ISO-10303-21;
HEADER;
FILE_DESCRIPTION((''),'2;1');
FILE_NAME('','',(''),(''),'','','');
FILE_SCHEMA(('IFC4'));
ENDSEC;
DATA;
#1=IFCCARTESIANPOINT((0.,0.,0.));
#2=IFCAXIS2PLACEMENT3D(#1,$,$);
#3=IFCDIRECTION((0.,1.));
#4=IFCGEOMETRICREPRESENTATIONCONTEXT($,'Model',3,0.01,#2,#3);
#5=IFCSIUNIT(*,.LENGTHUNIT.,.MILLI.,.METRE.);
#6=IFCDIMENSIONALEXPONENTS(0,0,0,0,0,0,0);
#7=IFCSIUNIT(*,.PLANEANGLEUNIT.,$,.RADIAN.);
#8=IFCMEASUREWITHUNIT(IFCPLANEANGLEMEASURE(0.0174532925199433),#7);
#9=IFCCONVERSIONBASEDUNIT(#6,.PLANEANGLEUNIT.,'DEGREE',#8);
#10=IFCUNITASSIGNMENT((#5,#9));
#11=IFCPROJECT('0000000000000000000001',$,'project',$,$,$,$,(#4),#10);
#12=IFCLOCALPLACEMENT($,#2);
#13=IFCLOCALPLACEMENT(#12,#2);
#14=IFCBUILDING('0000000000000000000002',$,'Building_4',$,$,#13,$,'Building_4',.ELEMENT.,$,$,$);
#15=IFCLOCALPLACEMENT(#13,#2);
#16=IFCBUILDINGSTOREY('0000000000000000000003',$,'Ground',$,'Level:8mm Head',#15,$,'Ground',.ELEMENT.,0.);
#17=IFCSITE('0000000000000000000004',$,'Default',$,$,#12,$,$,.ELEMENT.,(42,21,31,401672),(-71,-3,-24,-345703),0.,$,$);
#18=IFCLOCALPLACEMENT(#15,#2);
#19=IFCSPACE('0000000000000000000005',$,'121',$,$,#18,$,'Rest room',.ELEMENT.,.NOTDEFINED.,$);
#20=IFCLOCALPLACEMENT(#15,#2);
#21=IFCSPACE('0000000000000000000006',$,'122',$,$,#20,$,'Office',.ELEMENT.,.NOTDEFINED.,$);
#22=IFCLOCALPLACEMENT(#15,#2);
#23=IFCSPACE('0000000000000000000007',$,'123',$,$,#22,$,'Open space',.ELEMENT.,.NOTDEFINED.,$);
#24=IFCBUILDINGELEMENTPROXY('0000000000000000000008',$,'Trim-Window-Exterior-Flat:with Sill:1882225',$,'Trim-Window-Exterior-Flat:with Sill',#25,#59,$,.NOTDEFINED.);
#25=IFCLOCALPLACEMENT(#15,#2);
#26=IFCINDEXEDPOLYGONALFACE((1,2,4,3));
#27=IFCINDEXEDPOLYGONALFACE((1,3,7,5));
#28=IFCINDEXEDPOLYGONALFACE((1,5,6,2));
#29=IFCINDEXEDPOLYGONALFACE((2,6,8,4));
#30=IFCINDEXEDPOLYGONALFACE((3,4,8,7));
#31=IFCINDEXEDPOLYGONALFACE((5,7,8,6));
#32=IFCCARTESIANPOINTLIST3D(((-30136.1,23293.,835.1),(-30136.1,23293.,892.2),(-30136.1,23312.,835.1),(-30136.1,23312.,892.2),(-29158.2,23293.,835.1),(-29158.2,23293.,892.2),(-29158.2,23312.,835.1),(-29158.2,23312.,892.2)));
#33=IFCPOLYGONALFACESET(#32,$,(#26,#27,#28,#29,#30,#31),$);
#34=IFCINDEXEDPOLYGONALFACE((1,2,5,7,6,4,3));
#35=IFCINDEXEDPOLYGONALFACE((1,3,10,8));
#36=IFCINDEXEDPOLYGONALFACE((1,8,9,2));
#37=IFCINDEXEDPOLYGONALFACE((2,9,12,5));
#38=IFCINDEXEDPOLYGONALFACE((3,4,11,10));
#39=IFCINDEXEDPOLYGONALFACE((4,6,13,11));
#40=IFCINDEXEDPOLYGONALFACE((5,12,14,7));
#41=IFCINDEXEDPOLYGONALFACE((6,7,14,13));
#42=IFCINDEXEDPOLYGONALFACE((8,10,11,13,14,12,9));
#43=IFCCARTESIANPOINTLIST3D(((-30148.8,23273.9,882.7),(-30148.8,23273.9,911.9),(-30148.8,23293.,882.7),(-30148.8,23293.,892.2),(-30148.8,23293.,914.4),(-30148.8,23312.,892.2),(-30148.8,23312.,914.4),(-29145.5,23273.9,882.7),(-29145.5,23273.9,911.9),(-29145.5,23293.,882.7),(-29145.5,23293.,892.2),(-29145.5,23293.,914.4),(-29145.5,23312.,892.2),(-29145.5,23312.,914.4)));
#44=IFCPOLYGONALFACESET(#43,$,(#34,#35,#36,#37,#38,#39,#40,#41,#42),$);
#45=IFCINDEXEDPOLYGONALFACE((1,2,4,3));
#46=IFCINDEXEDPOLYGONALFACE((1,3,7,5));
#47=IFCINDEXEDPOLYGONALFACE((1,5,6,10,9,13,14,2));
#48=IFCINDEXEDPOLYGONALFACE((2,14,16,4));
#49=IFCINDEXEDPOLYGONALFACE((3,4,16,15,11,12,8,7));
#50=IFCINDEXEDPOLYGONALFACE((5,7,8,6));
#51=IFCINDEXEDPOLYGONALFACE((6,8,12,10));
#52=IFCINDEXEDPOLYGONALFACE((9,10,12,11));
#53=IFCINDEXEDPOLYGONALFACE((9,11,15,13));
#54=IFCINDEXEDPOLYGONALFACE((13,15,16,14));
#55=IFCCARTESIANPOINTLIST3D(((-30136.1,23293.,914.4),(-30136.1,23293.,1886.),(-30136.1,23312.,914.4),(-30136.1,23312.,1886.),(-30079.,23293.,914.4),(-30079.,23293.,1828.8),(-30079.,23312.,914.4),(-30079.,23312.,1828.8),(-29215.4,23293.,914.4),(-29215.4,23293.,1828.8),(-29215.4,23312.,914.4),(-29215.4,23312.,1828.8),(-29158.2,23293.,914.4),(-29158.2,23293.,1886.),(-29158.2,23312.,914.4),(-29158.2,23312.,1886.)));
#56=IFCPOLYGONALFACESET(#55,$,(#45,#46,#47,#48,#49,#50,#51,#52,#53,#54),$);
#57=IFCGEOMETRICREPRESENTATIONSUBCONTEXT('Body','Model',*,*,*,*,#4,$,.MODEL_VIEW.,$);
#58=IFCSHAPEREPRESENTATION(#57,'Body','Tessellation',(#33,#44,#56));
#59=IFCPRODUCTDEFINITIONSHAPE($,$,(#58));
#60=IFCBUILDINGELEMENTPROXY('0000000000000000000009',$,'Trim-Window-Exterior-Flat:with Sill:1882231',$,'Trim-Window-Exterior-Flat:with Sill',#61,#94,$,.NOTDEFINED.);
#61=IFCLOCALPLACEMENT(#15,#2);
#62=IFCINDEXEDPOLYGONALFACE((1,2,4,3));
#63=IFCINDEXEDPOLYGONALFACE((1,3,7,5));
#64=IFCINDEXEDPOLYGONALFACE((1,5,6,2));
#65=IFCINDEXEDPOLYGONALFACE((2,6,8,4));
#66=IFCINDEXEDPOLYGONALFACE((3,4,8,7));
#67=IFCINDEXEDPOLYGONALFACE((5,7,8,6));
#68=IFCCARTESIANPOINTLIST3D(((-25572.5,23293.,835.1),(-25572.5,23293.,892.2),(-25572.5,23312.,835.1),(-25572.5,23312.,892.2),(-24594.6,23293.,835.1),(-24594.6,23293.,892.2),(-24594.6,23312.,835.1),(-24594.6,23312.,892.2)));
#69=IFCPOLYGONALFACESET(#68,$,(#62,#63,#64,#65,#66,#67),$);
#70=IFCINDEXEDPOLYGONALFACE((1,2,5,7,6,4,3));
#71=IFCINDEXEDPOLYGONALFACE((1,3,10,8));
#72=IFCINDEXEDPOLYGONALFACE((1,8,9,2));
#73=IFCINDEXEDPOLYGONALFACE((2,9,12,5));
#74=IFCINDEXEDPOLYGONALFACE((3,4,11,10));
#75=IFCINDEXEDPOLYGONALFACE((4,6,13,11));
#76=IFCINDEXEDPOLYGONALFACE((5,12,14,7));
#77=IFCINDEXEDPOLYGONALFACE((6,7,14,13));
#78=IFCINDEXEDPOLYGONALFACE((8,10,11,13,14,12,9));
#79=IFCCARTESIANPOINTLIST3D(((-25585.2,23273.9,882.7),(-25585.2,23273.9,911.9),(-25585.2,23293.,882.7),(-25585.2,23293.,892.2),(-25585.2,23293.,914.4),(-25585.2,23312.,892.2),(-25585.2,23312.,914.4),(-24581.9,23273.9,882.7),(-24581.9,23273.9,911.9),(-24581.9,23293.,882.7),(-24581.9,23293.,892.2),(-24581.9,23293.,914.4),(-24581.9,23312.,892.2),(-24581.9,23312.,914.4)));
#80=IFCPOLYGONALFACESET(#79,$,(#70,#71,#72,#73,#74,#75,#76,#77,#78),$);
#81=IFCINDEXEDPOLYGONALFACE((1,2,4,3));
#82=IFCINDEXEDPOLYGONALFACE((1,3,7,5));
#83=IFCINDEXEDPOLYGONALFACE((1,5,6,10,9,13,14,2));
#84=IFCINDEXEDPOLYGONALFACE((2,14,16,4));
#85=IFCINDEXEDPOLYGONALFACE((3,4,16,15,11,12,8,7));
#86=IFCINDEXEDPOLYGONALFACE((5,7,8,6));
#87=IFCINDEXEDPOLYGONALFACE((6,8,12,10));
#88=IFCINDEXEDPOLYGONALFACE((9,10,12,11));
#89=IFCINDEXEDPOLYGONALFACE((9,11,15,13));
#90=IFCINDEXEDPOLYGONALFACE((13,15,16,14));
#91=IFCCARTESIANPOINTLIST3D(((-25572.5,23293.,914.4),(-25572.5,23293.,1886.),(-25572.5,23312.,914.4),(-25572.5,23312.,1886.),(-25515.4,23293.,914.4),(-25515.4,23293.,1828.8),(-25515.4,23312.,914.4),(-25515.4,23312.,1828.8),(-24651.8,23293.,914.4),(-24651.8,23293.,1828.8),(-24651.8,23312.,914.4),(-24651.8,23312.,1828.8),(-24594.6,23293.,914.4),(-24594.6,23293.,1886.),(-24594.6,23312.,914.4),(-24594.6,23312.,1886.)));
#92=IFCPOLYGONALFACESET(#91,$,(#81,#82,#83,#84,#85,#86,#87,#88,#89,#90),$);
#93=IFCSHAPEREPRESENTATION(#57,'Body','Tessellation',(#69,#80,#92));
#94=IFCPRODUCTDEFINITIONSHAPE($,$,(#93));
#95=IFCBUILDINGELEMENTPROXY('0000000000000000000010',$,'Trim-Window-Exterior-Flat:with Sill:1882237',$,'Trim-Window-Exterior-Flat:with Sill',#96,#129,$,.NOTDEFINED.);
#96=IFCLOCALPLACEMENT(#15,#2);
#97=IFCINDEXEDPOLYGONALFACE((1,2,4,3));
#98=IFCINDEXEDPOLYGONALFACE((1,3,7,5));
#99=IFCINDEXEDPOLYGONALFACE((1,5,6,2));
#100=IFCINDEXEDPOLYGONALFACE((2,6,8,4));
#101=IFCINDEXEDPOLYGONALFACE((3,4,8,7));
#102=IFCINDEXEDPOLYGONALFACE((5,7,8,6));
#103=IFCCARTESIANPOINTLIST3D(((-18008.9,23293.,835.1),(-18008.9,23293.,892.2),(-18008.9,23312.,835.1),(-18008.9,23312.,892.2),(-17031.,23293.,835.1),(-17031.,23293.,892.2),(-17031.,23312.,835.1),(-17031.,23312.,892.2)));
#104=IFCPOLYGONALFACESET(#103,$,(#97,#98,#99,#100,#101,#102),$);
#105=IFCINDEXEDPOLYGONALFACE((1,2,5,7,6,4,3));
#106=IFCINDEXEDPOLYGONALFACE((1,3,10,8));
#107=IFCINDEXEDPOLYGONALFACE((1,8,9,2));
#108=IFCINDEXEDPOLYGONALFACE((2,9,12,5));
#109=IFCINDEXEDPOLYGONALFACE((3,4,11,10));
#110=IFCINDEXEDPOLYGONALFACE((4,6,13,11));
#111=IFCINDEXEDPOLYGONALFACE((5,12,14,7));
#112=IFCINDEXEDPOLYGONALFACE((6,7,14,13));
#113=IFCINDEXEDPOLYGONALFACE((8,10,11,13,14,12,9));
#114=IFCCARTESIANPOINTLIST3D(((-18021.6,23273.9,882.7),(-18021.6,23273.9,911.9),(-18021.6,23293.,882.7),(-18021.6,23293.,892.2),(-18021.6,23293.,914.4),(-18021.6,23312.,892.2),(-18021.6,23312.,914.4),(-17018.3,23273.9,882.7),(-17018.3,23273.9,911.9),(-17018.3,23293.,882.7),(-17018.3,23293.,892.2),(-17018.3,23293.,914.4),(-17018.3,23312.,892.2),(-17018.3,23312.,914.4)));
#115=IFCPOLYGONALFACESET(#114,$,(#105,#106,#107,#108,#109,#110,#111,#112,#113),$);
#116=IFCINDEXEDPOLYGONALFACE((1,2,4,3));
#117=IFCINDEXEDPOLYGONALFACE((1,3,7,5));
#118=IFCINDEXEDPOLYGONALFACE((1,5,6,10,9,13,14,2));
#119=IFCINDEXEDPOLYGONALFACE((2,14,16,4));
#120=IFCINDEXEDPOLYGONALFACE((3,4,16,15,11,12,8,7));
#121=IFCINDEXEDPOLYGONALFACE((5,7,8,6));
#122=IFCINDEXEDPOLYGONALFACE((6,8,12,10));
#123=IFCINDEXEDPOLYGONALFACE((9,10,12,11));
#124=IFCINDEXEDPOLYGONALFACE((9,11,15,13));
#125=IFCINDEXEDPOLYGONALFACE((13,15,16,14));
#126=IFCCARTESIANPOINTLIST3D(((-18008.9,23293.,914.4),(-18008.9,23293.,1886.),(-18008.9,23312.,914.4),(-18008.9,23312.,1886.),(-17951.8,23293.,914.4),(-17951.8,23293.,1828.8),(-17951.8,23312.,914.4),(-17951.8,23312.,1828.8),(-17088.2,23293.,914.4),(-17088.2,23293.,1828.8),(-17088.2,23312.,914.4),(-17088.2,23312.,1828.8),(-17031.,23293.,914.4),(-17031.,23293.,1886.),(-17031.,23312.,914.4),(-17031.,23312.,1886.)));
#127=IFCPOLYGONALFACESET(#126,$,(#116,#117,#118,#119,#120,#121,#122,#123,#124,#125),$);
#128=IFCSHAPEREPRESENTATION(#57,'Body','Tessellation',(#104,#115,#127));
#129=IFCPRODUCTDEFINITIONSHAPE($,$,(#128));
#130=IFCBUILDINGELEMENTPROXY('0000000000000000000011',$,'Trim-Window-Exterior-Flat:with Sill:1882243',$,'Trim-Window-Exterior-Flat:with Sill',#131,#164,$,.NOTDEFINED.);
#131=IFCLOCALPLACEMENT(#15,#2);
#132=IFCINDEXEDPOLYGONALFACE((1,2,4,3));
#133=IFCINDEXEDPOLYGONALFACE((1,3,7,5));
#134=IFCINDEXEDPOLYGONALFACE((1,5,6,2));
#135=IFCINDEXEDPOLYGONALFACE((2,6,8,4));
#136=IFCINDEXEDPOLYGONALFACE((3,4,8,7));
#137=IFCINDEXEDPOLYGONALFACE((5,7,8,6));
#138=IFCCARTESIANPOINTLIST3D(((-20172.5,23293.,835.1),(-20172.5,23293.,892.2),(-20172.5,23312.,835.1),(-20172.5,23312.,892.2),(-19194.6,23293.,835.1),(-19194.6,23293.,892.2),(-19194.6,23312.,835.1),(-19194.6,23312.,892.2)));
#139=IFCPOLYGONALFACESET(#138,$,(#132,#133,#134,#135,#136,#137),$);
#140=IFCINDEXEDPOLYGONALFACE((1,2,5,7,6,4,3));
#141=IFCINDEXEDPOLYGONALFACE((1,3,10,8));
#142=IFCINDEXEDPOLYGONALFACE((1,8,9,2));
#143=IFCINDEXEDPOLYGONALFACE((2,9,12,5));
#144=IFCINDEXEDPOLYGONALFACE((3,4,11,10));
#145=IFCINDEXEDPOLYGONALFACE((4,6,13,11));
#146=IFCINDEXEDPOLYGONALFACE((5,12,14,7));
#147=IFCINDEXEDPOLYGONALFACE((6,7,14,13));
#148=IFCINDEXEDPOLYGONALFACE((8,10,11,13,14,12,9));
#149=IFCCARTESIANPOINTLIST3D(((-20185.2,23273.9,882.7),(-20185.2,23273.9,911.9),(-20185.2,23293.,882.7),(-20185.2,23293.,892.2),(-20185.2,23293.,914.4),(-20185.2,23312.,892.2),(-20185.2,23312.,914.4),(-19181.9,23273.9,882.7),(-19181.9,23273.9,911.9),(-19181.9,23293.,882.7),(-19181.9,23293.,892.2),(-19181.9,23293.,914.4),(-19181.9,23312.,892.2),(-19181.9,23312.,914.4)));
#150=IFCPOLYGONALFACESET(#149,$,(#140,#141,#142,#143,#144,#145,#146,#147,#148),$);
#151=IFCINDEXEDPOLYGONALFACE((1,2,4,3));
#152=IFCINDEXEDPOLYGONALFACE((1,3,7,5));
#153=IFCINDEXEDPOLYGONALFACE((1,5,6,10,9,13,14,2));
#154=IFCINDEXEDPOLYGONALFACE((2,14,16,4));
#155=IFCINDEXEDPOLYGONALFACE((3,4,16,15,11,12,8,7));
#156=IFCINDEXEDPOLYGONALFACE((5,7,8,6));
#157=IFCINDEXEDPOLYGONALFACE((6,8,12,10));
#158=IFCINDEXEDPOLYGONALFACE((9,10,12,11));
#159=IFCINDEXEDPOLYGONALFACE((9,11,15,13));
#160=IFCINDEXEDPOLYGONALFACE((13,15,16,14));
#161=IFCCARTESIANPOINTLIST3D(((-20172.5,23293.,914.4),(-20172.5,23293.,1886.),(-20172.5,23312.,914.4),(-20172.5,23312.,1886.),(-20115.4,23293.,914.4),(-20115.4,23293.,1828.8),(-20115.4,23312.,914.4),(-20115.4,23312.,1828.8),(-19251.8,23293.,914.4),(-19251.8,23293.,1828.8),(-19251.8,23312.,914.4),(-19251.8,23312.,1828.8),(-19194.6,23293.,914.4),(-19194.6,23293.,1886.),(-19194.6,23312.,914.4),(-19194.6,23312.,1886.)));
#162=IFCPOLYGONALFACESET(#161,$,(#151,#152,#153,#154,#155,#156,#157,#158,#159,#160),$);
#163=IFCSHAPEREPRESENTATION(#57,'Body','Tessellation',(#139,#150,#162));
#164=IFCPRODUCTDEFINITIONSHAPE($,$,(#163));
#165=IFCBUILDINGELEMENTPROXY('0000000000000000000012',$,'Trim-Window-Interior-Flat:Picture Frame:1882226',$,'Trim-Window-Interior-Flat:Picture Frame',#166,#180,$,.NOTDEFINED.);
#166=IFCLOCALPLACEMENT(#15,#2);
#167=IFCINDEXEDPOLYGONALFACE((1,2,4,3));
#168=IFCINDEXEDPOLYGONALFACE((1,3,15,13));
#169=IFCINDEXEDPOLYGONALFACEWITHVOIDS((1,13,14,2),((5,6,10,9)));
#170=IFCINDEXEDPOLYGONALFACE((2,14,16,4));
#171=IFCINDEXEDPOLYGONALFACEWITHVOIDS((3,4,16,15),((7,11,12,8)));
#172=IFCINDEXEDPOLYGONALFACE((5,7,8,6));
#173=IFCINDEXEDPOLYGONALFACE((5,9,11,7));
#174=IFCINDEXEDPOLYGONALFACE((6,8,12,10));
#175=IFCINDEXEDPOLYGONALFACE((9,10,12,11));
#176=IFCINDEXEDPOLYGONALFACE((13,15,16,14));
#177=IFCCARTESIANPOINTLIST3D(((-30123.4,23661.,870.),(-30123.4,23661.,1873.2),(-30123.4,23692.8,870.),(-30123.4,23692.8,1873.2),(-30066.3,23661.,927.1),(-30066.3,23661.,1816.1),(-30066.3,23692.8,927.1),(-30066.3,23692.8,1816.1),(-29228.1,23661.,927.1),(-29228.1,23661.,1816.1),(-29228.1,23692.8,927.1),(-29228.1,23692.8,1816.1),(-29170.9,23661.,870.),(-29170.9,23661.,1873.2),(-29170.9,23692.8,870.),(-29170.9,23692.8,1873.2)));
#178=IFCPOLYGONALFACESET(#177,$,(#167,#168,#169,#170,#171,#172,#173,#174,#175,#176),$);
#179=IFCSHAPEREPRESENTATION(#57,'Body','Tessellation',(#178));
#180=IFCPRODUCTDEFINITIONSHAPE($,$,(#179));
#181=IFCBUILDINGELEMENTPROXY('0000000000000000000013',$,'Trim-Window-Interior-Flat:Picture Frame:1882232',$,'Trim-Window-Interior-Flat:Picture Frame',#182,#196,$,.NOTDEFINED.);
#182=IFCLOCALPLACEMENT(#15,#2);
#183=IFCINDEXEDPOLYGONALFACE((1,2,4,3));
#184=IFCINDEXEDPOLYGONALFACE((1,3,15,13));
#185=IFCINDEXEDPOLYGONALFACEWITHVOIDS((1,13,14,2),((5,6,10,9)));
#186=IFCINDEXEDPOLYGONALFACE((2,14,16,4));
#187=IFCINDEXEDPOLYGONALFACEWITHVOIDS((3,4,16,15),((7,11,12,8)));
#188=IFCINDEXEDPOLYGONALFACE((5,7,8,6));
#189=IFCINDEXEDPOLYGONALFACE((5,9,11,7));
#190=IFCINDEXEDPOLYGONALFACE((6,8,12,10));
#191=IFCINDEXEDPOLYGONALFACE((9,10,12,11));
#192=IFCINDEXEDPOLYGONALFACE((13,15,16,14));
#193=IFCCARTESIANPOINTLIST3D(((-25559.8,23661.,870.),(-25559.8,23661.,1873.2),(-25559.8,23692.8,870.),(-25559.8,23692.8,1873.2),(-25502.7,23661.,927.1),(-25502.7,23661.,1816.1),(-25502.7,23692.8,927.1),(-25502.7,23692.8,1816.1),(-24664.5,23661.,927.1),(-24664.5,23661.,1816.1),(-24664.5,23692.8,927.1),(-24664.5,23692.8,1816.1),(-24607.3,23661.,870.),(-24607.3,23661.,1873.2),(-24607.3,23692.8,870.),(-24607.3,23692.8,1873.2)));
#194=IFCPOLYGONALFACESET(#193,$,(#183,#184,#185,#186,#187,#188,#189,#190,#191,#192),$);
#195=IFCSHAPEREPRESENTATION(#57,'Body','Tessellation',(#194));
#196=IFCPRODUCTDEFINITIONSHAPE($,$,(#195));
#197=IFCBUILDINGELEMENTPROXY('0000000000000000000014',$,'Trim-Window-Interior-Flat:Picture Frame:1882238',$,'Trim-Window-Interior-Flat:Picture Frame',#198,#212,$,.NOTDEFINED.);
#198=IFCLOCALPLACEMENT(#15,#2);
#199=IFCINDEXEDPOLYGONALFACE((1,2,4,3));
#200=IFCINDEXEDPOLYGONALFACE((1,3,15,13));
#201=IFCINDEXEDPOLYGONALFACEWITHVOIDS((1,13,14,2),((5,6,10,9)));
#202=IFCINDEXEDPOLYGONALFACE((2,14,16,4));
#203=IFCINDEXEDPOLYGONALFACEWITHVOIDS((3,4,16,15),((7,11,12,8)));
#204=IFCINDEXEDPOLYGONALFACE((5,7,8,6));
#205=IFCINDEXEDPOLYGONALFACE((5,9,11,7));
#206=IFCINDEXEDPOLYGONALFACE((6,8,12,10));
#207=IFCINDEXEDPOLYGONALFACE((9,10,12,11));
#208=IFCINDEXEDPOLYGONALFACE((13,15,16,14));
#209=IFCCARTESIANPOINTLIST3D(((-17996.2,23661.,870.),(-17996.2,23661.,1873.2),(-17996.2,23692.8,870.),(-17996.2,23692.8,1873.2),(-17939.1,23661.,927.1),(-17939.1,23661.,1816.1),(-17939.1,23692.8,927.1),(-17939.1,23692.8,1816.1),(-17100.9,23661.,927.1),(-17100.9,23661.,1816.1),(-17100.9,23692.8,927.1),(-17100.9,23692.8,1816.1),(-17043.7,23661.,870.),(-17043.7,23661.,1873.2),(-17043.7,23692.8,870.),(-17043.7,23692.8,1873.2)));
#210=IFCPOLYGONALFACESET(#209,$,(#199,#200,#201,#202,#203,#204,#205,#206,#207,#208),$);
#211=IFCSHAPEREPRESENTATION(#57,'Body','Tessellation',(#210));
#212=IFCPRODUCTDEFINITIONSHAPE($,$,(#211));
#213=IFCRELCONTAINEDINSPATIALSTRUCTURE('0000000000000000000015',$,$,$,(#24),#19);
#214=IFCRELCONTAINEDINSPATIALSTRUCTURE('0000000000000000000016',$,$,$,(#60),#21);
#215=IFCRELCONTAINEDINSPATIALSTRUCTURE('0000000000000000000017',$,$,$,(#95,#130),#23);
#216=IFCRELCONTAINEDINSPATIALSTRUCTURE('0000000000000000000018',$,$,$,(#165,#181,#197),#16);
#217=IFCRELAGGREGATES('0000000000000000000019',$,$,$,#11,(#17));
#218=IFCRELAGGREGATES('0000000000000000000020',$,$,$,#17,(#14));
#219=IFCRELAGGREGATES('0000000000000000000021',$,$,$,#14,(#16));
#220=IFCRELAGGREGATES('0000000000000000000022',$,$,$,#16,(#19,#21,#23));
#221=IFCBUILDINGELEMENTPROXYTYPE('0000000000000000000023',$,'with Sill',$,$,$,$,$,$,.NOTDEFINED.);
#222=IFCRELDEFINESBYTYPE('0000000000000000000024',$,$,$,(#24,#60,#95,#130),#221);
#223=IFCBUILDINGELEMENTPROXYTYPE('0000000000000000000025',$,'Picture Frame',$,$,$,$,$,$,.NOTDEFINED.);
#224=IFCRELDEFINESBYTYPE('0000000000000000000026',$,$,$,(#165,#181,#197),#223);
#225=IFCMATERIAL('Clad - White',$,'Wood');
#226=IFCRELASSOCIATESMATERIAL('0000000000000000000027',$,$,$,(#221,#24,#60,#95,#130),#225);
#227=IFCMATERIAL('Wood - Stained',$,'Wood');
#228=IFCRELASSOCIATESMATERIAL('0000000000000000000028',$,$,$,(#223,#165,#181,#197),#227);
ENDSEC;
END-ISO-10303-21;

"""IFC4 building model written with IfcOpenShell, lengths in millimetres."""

from ifc_helpers import new_model, entity, si_unit, converted_unit, direction, frame, origin, place, context, subcontext, project, spatial, indexed_curve, outline, extrude, source, transform, mapped, material, type_object, type_shapes, element, save


model = new_model("IFC4")

# Units and contexts
model_context = context("Model", 3, precision=0.01, world=origin(), true_north=direction((0.0, 1.0)))
body_context = subcontext(model_context, "Body", "Model", "MODEL_VIEW")
ifc_project = project(units=[si_unit("LENGTHUNIT", "METRE", prefix="MILLI"), converted_unit("PLANEANGLEUNIT", "DEGREE", entity("IfcPlaneAngleMeasure", 0.0174532925199433), si_unit("PLANEANGLEUNIT", "RADIAN"), dimensions=[0, 0, 0, 0, 0, 0, 0])], contexts=[model_context])

# Site, building, storey
site_placement = place(None, origin())
site = spatial("IfcSite", under=ifc_project, at=site_placement, Name="Default", CompositionType="ELEMENT", RefLatitude=(42, 21, 31, 401672), RefLongitude=(-71, -3, -24, -345703), RefElevation=0.0)
building_placement = place(site_placement, origin())
building = spatial("IfcBuilding", under=site, at=building_placement, Name="Building_4", LongName="Building_4", CompositionType="ELEMENT")
storey_placement = place(building_placement, origin())
storey = spatial("IfcBuildingStorey", under=building, at=storey_placement, Name="Ground", ObjectType="Level:8mm Head", LongName="Ground", CompositionType="ELEMENT", Elevation=0.0)

# Shared definitions
ifc_material_1 = material(Name="Clad - White", Category="Wood")
ifc_material_2 = material(Name="Wood - Stained", Category="Wood")

# Shared definitions
space_1_placement = place(storey_placement, origin())
space_1 = spatial("IfcSpace", under=storey, at=space_1_placement, Name="121", LongName="Rest room", CompositionType="ELEMENT", PredefinedType="NOTDEFINED")

# Building element proxy
building_element_proxy_type_1 = type_object("IfcBuildingElementProxyType", Name="with Sill", PredefinedType="NOTDEFINED", material=ifc_material_1)
shared_shape_1 = source(origin(), body_context, "Body", "SweptSolid", [
    extrude(outline(indexed_curve([(-488.9, -28.6), (488.9, -28.6), (488.9, 28.6), (-488.9, 28.6), (-488.9, -28.6)], self_intersect=False)), frame((0.0, -965.2, 0.0), z_axis=(0.0, 0.0, 1.0), x_axis=(-1.0, 0.0, 0.0)), (0.0, 0.0, 1.0), 19.1),
    extrude(outline(indexed_curve([(-19.0, -16.0), (0.0, -16.0), (0.0, -6.4), (19.0, -6.4), (19.0, 15.8), (0.0, 15.8), (-19.0, 13.3), (-19.0, -16.0)], self_intersect=False)), frame((-501.6, -930.2, 19.0), z_axis=(1.0, 0.0, 0.0), x_axis=(0.0, 0.0, -1.0)), (0.0, 0.0, 1.0), 1003.3),
    extrude(outline(indexed_curve([(-500.1, -488.9), (471.5, -488.9), (471.5, -431.8), (-442.9, -431.8), (-442.9, 431.8), (471.5, 431.8), (471.5, 488.9), (-500.1, 488.9), (-500.1, -488.9)], self_intersect=False)), frame((0.0, -442.9, 0.0), z_axis=(0.0, 0.0, 1.0), x_axis=(0.0, -1.0, 0.0)), (0.0, 0.0, 1.0), 19.1),
])
type_shapes(building_element_proxy_type_1, [shared_shape_1])
proxy_1_placement = place(space_1_placement, frame((-29647.2, 23312.0, 1828.8), z_axis=(0.0, -1.0, 0.0), x_axis=(1.0, 0.0, 0.0)))
element("IfcBuildingElementProxy", 1, at=proxy_1_placement, inside=space_1, type_object=building_element_proxy_type_1, material=ifc_material_1, Name="Trim-Window-Exterior-Flat:with Sill:1882225", ObjectType="Trim-Window-Exterior-Flat:with Sill", PredefinedType="NOTDEFINED", context=body_context, shape_type="MappedRepresentation", body=[
    mapped(shared_shape_1, transform((0.0, 0.0, 0.0), scale=1.0)),
])

# Shared definitions
space_2_placement = place(storey_placement, origin())
space_2 = spatial("IfcSpace", under=storey, at=space_2_placement, Name="122", LongName="Office", CompositionType="ELEMENT", PredefinedType="NOTDEFINED")

# Building element proxy
proxy_2_placement = place(space_2_placement, frame((-25083.6, 23312.0, 1828.8), z_axis=(0.0, -1.0, 0.0), x_axis=(1.0, 0.0, 0.0)))
element("IfcBuildingElementProxy", 2, at=proxy_2_placement, inside=space_2, type_object=building_element_proxy_type_1, material=ifc_material_1, Name="Trim-Window-Exterior-Flat:with Sill:1882231", ObjectType="Trim-Window-Exterior-Flat:with Sill", PredefinedType="NOTDEFINED", context=body_context, shape_type="MappedRepresentation", body=[
    mapped(shared_shape_1, transform((0.0, 0.0, 0.0), scale=1.0)),
])

# Shared definitions
space_3_placement = place(storey_placement, origin())
space_3 = spatial("IfcSpace", under=storey, at=space_3_placement, Name="123", LongName="Open space", CompositionType="ELEMENT", PredefinedType="NOTDEFINED")

# Building element proxies
for number, where, z_axis, x_axis, name in (
    (3, (-17520.0, 23312.0, 1828.8), (0.0, -1.0, 0.0), (1.0, 0.0, 0.0), "Trim-Window-Exterior-Flat:with Sill:1882237"),
    (4, (-19683.6, 23312.0, 1828.8), (0.0, -1.0, 0.0), (1.0, 0.0, 0.0), "Trim-Window-Exterior-Flat:with Sill:1882243"),
):
    element("IfcBuildingElementProxy", number, at=place(space_3_placement, frame(where, z_axis=z_axis, x_axis=x_axis)), inside=space_3, type_object=building_element_proxy_type_1, material=ifc_material_1, Name=name, ObjectType="Trim-Window-Exterior-Flat:with Sill", PredefinedType="NOTDEFINED", context=body_context, shape_type="MappedRepresentation", body=[
        mapped(shared_shape_1, transform((0.0, 0.0, 0.0), scale=1.0)),
    ])
building_element_proxy_type_2 = type_object("IfcBuildingElementProxyType", Name="Picture Frame", PredefinedType="NOTDEFINED", material=ifc_material_2)
shared_shape_2 = source(origin(), body_context, "Body", "SweptSolid", [
    extrude(outline(indexed_curve([(-476.2, -501.6), (476.2, -501.6), (476.2, 501.6), (-476.2, 501.6), (-476.2, -501.6)], self_intersect=False), holes=[indexed_curve([(-419.1, -444.5), (-419.1, 444.5), (419.1, 444.5), (419.1, -444.5), (-419.1, -444.5)], self_intersect=False)]), frame((0.0, -457.2, 0.0), z_axis=(0.0, 0.0, 1.0), x_axis=(-1.0, 0.0, 0.0)), (0.0, 0.0, 1.0), 31.8),
])
type_shapes(building_element_proxy_type_2, [shared_shape_2])
for number, where, z_axis, x_axis, name in (
    (5, (-29647.2, 23661.0, 1828.8), (0.0, 1.0, 0.0), (-1.0, 0.0, 0.0), "Trim-Window-Interior-Flat:Picture Frame:1882226"),
    (6, (-25083.6, 23661.0, 1828.8), (0.0, 1.0, 0.0), (-1.0, 0.0, 0.0), "Trim-Window-Interior-Flat:Picture Frame:1882232"),
    (7, (-17520.0, 23661.0, 1828.8), (0.0, 1.0, 0.0), (-1.0, 0.0, 0.0), "Trim-Window-Interior-Flat:Picture Frame:1882238"),
):
    element("IfcBuildingElementProxy", number, at=place(storey_placement, frame(where, z_axis=z_axis, x_axis=x_axis)), inside=storey, type_object=building_element_proxy_type_2, material=ifc_material_2, Name=name, ObjectType="Trim-Window-Interior-Flat:Picture Frame", PredefinedType="NOTDEFINED", context=body_context, shape_type="MappedRepresentation", body=[
        mapped(shared_shape_2, transform((0.0, 0.0, 0.0), scale=1.0)),
    ])

save(model, "model.ifc")
